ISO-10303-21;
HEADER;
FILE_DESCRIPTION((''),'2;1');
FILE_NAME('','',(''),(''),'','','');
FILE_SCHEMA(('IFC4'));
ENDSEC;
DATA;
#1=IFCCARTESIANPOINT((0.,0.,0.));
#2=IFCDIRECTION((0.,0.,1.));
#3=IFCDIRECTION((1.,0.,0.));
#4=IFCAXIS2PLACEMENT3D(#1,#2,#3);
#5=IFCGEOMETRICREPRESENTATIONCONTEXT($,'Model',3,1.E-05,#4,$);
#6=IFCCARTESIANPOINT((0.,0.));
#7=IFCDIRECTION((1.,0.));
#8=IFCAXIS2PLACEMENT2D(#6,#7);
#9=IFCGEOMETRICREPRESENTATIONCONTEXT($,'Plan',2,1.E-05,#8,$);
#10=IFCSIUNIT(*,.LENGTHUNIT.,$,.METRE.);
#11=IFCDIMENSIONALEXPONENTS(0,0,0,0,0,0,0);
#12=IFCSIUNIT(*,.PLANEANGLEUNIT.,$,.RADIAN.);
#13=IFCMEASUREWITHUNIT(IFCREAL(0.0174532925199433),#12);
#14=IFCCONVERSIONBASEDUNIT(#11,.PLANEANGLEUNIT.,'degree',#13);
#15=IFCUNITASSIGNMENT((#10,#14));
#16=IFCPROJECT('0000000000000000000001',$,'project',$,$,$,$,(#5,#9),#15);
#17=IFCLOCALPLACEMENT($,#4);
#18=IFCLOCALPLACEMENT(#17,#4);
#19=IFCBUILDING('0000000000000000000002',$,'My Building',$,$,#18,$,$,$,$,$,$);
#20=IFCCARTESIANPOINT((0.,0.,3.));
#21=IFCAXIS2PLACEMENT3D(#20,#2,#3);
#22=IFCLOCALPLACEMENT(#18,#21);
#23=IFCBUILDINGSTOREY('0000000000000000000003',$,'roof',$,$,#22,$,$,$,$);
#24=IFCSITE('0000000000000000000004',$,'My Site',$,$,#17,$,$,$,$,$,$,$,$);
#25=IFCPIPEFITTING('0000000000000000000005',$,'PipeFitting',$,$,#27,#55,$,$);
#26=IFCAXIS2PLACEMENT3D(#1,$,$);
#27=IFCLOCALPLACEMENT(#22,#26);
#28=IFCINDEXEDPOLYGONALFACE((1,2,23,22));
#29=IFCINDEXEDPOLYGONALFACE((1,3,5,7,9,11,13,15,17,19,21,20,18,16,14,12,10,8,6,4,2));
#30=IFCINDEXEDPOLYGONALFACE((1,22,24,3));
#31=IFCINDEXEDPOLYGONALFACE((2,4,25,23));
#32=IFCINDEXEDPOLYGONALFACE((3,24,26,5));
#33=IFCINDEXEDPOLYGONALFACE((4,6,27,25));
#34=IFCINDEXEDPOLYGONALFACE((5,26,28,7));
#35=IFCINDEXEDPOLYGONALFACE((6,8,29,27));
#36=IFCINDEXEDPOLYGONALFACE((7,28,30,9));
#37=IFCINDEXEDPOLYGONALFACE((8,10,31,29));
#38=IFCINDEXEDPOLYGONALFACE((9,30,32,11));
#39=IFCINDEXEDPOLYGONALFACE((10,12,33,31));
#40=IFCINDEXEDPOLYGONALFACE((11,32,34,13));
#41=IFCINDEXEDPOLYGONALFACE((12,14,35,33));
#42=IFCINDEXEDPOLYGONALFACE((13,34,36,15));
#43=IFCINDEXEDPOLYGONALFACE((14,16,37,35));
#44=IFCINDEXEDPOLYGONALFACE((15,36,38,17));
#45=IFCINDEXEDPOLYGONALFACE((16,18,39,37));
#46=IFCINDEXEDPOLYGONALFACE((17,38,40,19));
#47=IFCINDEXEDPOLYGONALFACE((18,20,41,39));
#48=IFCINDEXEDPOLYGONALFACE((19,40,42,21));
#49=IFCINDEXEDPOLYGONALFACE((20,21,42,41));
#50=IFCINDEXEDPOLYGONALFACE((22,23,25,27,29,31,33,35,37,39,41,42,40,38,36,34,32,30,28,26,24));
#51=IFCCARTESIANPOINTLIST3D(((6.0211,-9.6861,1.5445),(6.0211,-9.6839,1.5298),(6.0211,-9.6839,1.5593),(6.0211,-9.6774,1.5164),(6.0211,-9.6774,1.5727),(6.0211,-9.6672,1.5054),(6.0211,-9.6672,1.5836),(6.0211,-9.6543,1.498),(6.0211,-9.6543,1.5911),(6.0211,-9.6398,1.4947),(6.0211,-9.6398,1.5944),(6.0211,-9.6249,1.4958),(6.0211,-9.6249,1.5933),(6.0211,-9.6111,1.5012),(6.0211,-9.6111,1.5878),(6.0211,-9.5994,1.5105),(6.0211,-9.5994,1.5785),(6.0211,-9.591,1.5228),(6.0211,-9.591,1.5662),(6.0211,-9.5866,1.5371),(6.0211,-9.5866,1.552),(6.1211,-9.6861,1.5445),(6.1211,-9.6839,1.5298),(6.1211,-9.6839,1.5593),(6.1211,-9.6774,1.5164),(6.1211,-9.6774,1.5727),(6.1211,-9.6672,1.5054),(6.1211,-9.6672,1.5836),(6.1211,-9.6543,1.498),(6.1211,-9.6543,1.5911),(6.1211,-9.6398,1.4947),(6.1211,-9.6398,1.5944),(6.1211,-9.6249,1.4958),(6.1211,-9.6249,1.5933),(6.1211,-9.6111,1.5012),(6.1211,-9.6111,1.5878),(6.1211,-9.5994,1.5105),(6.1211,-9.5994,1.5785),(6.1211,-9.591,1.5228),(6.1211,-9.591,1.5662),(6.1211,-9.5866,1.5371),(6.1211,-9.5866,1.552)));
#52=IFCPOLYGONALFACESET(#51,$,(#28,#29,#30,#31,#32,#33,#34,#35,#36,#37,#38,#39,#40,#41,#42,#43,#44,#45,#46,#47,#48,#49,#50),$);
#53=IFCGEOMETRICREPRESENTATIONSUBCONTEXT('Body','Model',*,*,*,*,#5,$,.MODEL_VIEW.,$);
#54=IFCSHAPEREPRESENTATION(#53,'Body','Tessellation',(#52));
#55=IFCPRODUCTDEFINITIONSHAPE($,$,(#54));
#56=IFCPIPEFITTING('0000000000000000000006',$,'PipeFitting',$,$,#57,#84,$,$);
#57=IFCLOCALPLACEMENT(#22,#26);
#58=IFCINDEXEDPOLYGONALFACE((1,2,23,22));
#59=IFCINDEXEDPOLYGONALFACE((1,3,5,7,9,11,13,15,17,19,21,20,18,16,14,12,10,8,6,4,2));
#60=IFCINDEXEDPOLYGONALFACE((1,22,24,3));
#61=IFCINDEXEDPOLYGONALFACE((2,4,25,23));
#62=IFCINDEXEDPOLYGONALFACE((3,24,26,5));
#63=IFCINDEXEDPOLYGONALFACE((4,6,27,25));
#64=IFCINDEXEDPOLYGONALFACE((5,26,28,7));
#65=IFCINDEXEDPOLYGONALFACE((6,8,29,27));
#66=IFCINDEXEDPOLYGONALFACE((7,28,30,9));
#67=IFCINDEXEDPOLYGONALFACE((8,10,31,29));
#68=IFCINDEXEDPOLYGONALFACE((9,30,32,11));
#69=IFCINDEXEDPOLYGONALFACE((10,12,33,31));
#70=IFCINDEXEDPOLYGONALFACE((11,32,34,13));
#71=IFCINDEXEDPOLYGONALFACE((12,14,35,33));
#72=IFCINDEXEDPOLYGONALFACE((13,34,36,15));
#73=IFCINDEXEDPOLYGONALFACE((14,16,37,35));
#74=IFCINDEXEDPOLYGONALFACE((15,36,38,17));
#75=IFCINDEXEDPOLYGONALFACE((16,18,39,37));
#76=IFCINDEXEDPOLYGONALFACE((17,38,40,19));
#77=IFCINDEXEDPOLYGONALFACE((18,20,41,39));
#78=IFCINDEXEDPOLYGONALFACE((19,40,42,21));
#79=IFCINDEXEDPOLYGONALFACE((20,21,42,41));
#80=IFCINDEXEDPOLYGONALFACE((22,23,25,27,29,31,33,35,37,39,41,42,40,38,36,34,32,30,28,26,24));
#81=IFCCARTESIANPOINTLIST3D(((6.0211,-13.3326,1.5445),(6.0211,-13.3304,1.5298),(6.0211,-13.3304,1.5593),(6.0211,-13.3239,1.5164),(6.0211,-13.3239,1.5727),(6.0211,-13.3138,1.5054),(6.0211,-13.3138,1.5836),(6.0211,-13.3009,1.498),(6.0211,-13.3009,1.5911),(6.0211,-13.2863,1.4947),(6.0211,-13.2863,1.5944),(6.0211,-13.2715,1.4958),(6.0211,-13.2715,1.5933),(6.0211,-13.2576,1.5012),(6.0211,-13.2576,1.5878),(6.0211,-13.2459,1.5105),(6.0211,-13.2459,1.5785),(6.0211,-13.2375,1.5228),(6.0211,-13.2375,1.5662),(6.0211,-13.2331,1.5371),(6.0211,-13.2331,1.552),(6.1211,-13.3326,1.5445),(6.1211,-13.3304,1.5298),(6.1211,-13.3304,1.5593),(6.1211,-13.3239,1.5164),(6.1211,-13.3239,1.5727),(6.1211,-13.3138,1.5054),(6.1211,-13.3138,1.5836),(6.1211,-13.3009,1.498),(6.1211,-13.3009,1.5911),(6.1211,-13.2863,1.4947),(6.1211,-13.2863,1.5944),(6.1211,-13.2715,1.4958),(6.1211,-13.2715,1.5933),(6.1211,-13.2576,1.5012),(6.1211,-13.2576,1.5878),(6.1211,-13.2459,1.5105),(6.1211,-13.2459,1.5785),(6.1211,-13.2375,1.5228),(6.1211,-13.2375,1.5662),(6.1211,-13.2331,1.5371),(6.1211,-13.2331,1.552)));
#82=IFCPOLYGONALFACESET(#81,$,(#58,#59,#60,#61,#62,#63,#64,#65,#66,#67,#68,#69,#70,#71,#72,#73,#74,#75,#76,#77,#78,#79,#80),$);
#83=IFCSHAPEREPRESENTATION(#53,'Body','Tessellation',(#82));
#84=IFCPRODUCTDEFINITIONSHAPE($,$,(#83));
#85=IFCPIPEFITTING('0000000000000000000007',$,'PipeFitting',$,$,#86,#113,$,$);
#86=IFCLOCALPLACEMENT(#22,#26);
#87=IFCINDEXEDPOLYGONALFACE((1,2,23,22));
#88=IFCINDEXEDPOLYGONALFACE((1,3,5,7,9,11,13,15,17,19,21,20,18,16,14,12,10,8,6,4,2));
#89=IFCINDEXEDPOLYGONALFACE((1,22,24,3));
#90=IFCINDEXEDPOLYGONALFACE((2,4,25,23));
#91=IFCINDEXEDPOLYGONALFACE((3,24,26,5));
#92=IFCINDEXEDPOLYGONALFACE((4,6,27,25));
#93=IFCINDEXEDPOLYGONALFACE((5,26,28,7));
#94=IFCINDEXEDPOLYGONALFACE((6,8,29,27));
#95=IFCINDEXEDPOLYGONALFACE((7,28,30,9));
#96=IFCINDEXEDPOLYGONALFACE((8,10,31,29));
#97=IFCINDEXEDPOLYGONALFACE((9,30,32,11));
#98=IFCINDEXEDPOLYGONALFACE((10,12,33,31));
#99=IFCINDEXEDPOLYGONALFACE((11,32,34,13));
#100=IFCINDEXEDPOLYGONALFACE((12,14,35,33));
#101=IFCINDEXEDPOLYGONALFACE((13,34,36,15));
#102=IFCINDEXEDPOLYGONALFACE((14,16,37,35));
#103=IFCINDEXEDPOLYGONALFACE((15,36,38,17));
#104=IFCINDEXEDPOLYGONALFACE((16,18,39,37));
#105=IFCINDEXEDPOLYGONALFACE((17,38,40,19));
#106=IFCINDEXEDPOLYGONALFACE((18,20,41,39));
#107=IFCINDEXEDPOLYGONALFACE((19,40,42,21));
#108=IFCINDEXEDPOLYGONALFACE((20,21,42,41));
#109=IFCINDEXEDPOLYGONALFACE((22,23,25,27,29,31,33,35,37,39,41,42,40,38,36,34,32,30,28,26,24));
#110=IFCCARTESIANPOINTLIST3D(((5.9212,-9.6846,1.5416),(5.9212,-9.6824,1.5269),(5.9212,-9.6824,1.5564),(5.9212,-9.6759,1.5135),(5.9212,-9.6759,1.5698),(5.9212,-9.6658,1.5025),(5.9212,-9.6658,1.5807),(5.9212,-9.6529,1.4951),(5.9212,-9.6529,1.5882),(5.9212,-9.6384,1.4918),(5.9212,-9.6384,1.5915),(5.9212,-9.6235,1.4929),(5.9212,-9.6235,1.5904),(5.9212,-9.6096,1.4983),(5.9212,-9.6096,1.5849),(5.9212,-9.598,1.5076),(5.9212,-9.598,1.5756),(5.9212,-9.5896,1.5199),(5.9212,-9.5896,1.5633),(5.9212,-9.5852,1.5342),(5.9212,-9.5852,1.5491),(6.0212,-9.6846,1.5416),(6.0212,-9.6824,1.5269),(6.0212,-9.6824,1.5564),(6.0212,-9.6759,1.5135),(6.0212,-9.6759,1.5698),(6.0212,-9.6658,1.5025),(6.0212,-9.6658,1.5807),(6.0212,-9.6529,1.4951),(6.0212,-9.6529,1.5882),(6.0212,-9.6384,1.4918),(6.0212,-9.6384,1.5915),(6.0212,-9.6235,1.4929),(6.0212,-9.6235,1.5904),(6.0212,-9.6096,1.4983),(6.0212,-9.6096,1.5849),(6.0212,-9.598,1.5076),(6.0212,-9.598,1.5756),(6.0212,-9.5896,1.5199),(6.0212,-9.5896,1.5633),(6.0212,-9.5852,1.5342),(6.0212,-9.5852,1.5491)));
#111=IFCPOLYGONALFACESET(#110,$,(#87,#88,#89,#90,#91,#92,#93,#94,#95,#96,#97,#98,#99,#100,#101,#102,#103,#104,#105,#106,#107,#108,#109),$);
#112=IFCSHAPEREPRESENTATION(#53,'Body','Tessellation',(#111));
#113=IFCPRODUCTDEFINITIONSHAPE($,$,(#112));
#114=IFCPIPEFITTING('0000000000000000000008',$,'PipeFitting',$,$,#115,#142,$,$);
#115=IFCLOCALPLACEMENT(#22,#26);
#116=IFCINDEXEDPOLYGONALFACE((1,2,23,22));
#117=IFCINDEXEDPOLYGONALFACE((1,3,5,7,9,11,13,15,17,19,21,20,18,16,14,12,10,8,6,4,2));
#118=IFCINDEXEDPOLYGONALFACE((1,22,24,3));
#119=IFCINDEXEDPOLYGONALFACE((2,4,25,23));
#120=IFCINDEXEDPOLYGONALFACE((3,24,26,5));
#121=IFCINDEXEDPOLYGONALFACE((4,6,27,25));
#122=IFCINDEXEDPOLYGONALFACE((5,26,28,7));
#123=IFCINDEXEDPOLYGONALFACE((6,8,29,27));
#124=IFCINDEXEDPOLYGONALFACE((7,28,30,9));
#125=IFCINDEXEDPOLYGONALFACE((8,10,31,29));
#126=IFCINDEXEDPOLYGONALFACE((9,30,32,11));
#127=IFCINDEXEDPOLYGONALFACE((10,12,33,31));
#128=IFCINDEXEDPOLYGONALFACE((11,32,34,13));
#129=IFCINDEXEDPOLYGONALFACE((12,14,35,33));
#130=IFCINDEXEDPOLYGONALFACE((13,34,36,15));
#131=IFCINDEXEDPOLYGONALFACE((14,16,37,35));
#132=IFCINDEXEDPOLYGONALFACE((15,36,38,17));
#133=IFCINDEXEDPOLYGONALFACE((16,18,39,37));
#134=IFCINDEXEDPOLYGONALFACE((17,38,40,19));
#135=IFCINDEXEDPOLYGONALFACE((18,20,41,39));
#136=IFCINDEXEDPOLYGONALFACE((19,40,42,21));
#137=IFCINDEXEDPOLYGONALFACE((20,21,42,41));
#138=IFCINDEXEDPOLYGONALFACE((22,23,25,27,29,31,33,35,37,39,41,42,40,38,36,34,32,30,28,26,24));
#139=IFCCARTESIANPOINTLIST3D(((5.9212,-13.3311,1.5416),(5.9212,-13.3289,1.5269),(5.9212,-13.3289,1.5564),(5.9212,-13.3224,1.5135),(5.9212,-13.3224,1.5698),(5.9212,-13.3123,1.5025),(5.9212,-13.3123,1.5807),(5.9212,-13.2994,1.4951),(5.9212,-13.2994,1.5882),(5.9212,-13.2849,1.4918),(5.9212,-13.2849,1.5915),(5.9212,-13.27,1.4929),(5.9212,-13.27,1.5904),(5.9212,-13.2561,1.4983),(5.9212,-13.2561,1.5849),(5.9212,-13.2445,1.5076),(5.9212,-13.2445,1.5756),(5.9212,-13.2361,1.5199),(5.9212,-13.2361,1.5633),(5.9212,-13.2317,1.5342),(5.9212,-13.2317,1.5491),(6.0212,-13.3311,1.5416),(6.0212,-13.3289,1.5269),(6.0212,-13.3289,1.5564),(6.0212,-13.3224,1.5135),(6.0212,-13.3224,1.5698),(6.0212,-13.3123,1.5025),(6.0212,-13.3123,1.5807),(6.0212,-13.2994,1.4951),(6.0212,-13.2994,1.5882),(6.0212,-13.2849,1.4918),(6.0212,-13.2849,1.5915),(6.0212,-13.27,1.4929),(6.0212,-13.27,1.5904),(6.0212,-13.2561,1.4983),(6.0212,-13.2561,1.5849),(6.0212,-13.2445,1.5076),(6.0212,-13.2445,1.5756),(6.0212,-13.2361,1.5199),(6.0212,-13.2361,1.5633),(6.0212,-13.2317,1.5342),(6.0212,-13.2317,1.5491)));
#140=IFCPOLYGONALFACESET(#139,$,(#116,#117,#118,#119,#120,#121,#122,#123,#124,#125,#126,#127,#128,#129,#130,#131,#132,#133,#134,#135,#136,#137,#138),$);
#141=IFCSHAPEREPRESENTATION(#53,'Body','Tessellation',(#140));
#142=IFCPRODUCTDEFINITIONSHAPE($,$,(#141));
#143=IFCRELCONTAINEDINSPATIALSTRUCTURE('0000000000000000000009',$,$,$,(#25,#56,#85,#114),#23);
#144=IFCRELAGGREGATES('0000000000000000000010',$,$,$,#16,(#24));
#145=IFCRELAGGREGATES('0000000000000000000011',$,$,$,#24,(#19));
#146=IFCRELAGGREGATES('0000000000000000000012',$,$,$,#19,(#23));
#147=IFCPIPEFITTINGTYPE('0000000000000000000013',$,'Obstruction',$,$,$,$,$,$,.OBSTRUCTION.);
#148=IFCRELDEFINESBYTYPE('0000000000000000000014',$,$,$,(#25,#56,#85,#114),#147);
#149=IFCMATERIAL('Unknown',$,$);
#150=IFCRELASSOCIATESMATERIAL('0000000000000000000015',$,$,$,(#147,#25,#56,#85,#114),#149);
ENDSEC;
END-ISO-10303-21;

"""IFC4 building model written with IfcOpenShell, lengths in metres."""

from ifc_helpers import new_model, entity, si_unit, converted_unit, frame, origin_with_axes, origin_2d_with_axis, place, context, subcontext, project, spatial, circle, extrude, material, material_profile, profile_set, profile_usage, type_object, element, save


model = new_model("IFC4")

# Units and contexts
model_context = context("Model", 3, precision=1e-05, world=origin_with_axes())
plan_context = context("Plan", 2, precision=1e-05, world=origin_2d_with_axis())
body_context_1 = subcontext(model_context, "Body", "Model", "MODEL_VIEW")
ifc_project = project(units=[si_unit("LENGTHUNIT", "METRE"), converted_unit("PLANEANGLEUNIT", "degree", entity("IfcReal", 0.0174532925199433), si_unit("PLANEANGLEUNIT", "RADIAN"), dimensions=[0, 0, 0, 0, 0, 0, 0])], contexts=[model_context, plan_context])

# Site, building, storey
site_placement = place(None, origin_with_axes())
site = spatial("IfcSite", under=ifc_project, at=site_placement, Name="My Site")
building_placement = place(site_placement, origin_with_axes())
building = spatial("IfcBuilding", under=site, at=building_placement, Name="My Building")
storey_placement = place(building_placement, frame((0.0, 0.0, 3.0), z_axis=(0.0, 0.0, 1.0), x_axis=(1.0, 0.0, 0.0)))
storey = spatial("IfcBuildingStorey", under=building, at=storey_placement, Name="roof")

# Shared definitions
ifc_material = material(Name="Unknown")

# Pipe fittings
ifc_material_profile_1 = material_profile(ifc_material, circle(Radius=0.05))
ifc_profile_set_1 = profile_set([ifc_material_profile_1])
ifc_profile_usage_1 = profile_usage(ifc_profile_set_1, cardinal=5)
pipe_fitting_type_1 = type_object("IfcPipeFittingType", Name="Obstruction", PredefinedType="OBSTRUCTION", material=ifc_profile_set_1)
pipe_fitting_1_placement = place(storey_placement, frame((6.0211, -9.6361, 1.5445), z_axis=(1.0, 0.0, 0.0), x_axis=(0.0, -1.0, 0.0)))
element("IfcPipeFitting", 1, at=pipe_fitting_1_placement, inside=storey, type_object=pipe_fitting_type_1, material=ifc_profile_usage_1, Name="PipeFitting", context=body_context_1, shape_type="SweptSolid", body=[
    extrude(circle(Radius=0.05), origin_with_axes(), (0.0, 0.0, 1.0), 0.1),
])
ifc_profile_usage_2 = profile_usage(ifc_profile_set_1, cardinal=5)
pipe_fitting_2_placement = place(storey_placement, frame((6.0211, -13.2826, 1.5445), z_axis=(1.0, 0.0, 0.0), x_axis=(0.0, -1.0, 0.0)))
element("IfcPipeFitting", 2, at=pipe_fitting_2_placement, inside=storey, type_object=pipe_fitting_type_1, material=ifc_profile_usage_2, Name="PipeFitting", context=body_context_1, shape_type="SweptSolid", body=[
    extrude(circle(Radius=0.05), origin_with_axes(), (0.0, 0.0, 1.0), 0.1),
])
ifc_profile_usage_3 = profile_usage(ifc_profile_set_1, cardinal=5)
pipe_fitting_3_placement = place(storey_placement, frame((6.0212, -9.6346, 1.5416), z_axis=(-1.0, 0.0, 0.0), x_axis=(0.0, -1.0, 0.0)))
element("IfcPipeFitting", 3, at=pipe_fitting_3_placement, inside=storey, type_object=pipe_fitting_type_1, material=ifc_profile_usage_3, Name="PipeFitting", context=body_context_1, shape_type="SweptSolid", body=[
    extrude(circle(Radius=0.05), origin_with_axes(), (0.0, 0.0, 1.0), 0.1),
])
ifc_profile_usage_4 = profile_usage(ifc_profile_set_1, cardinal=5)
pipe_fitting_4_placement = place(storey_placement, frame((6.0212, -13.2811, 1.5416), z_axis=(-1.0, 0.0, 0.0), x_axis=(0.0, -1.0, 0.0)))
element("IfcPipeFitting", 4, at=pipe_fitting_4_placement, inside=storey, type_object=pipe_fitting_type_1, material=ifc_profile_usage_4, Name="PipeFitting", context=body_context_1, shape_type="SweptSolid", body=[
    extrude(circle(Radius=0.05), origin_with_axes(), (0.0, 0.0, 1.0), 0.1),
])

save(model, "model.ifc")
